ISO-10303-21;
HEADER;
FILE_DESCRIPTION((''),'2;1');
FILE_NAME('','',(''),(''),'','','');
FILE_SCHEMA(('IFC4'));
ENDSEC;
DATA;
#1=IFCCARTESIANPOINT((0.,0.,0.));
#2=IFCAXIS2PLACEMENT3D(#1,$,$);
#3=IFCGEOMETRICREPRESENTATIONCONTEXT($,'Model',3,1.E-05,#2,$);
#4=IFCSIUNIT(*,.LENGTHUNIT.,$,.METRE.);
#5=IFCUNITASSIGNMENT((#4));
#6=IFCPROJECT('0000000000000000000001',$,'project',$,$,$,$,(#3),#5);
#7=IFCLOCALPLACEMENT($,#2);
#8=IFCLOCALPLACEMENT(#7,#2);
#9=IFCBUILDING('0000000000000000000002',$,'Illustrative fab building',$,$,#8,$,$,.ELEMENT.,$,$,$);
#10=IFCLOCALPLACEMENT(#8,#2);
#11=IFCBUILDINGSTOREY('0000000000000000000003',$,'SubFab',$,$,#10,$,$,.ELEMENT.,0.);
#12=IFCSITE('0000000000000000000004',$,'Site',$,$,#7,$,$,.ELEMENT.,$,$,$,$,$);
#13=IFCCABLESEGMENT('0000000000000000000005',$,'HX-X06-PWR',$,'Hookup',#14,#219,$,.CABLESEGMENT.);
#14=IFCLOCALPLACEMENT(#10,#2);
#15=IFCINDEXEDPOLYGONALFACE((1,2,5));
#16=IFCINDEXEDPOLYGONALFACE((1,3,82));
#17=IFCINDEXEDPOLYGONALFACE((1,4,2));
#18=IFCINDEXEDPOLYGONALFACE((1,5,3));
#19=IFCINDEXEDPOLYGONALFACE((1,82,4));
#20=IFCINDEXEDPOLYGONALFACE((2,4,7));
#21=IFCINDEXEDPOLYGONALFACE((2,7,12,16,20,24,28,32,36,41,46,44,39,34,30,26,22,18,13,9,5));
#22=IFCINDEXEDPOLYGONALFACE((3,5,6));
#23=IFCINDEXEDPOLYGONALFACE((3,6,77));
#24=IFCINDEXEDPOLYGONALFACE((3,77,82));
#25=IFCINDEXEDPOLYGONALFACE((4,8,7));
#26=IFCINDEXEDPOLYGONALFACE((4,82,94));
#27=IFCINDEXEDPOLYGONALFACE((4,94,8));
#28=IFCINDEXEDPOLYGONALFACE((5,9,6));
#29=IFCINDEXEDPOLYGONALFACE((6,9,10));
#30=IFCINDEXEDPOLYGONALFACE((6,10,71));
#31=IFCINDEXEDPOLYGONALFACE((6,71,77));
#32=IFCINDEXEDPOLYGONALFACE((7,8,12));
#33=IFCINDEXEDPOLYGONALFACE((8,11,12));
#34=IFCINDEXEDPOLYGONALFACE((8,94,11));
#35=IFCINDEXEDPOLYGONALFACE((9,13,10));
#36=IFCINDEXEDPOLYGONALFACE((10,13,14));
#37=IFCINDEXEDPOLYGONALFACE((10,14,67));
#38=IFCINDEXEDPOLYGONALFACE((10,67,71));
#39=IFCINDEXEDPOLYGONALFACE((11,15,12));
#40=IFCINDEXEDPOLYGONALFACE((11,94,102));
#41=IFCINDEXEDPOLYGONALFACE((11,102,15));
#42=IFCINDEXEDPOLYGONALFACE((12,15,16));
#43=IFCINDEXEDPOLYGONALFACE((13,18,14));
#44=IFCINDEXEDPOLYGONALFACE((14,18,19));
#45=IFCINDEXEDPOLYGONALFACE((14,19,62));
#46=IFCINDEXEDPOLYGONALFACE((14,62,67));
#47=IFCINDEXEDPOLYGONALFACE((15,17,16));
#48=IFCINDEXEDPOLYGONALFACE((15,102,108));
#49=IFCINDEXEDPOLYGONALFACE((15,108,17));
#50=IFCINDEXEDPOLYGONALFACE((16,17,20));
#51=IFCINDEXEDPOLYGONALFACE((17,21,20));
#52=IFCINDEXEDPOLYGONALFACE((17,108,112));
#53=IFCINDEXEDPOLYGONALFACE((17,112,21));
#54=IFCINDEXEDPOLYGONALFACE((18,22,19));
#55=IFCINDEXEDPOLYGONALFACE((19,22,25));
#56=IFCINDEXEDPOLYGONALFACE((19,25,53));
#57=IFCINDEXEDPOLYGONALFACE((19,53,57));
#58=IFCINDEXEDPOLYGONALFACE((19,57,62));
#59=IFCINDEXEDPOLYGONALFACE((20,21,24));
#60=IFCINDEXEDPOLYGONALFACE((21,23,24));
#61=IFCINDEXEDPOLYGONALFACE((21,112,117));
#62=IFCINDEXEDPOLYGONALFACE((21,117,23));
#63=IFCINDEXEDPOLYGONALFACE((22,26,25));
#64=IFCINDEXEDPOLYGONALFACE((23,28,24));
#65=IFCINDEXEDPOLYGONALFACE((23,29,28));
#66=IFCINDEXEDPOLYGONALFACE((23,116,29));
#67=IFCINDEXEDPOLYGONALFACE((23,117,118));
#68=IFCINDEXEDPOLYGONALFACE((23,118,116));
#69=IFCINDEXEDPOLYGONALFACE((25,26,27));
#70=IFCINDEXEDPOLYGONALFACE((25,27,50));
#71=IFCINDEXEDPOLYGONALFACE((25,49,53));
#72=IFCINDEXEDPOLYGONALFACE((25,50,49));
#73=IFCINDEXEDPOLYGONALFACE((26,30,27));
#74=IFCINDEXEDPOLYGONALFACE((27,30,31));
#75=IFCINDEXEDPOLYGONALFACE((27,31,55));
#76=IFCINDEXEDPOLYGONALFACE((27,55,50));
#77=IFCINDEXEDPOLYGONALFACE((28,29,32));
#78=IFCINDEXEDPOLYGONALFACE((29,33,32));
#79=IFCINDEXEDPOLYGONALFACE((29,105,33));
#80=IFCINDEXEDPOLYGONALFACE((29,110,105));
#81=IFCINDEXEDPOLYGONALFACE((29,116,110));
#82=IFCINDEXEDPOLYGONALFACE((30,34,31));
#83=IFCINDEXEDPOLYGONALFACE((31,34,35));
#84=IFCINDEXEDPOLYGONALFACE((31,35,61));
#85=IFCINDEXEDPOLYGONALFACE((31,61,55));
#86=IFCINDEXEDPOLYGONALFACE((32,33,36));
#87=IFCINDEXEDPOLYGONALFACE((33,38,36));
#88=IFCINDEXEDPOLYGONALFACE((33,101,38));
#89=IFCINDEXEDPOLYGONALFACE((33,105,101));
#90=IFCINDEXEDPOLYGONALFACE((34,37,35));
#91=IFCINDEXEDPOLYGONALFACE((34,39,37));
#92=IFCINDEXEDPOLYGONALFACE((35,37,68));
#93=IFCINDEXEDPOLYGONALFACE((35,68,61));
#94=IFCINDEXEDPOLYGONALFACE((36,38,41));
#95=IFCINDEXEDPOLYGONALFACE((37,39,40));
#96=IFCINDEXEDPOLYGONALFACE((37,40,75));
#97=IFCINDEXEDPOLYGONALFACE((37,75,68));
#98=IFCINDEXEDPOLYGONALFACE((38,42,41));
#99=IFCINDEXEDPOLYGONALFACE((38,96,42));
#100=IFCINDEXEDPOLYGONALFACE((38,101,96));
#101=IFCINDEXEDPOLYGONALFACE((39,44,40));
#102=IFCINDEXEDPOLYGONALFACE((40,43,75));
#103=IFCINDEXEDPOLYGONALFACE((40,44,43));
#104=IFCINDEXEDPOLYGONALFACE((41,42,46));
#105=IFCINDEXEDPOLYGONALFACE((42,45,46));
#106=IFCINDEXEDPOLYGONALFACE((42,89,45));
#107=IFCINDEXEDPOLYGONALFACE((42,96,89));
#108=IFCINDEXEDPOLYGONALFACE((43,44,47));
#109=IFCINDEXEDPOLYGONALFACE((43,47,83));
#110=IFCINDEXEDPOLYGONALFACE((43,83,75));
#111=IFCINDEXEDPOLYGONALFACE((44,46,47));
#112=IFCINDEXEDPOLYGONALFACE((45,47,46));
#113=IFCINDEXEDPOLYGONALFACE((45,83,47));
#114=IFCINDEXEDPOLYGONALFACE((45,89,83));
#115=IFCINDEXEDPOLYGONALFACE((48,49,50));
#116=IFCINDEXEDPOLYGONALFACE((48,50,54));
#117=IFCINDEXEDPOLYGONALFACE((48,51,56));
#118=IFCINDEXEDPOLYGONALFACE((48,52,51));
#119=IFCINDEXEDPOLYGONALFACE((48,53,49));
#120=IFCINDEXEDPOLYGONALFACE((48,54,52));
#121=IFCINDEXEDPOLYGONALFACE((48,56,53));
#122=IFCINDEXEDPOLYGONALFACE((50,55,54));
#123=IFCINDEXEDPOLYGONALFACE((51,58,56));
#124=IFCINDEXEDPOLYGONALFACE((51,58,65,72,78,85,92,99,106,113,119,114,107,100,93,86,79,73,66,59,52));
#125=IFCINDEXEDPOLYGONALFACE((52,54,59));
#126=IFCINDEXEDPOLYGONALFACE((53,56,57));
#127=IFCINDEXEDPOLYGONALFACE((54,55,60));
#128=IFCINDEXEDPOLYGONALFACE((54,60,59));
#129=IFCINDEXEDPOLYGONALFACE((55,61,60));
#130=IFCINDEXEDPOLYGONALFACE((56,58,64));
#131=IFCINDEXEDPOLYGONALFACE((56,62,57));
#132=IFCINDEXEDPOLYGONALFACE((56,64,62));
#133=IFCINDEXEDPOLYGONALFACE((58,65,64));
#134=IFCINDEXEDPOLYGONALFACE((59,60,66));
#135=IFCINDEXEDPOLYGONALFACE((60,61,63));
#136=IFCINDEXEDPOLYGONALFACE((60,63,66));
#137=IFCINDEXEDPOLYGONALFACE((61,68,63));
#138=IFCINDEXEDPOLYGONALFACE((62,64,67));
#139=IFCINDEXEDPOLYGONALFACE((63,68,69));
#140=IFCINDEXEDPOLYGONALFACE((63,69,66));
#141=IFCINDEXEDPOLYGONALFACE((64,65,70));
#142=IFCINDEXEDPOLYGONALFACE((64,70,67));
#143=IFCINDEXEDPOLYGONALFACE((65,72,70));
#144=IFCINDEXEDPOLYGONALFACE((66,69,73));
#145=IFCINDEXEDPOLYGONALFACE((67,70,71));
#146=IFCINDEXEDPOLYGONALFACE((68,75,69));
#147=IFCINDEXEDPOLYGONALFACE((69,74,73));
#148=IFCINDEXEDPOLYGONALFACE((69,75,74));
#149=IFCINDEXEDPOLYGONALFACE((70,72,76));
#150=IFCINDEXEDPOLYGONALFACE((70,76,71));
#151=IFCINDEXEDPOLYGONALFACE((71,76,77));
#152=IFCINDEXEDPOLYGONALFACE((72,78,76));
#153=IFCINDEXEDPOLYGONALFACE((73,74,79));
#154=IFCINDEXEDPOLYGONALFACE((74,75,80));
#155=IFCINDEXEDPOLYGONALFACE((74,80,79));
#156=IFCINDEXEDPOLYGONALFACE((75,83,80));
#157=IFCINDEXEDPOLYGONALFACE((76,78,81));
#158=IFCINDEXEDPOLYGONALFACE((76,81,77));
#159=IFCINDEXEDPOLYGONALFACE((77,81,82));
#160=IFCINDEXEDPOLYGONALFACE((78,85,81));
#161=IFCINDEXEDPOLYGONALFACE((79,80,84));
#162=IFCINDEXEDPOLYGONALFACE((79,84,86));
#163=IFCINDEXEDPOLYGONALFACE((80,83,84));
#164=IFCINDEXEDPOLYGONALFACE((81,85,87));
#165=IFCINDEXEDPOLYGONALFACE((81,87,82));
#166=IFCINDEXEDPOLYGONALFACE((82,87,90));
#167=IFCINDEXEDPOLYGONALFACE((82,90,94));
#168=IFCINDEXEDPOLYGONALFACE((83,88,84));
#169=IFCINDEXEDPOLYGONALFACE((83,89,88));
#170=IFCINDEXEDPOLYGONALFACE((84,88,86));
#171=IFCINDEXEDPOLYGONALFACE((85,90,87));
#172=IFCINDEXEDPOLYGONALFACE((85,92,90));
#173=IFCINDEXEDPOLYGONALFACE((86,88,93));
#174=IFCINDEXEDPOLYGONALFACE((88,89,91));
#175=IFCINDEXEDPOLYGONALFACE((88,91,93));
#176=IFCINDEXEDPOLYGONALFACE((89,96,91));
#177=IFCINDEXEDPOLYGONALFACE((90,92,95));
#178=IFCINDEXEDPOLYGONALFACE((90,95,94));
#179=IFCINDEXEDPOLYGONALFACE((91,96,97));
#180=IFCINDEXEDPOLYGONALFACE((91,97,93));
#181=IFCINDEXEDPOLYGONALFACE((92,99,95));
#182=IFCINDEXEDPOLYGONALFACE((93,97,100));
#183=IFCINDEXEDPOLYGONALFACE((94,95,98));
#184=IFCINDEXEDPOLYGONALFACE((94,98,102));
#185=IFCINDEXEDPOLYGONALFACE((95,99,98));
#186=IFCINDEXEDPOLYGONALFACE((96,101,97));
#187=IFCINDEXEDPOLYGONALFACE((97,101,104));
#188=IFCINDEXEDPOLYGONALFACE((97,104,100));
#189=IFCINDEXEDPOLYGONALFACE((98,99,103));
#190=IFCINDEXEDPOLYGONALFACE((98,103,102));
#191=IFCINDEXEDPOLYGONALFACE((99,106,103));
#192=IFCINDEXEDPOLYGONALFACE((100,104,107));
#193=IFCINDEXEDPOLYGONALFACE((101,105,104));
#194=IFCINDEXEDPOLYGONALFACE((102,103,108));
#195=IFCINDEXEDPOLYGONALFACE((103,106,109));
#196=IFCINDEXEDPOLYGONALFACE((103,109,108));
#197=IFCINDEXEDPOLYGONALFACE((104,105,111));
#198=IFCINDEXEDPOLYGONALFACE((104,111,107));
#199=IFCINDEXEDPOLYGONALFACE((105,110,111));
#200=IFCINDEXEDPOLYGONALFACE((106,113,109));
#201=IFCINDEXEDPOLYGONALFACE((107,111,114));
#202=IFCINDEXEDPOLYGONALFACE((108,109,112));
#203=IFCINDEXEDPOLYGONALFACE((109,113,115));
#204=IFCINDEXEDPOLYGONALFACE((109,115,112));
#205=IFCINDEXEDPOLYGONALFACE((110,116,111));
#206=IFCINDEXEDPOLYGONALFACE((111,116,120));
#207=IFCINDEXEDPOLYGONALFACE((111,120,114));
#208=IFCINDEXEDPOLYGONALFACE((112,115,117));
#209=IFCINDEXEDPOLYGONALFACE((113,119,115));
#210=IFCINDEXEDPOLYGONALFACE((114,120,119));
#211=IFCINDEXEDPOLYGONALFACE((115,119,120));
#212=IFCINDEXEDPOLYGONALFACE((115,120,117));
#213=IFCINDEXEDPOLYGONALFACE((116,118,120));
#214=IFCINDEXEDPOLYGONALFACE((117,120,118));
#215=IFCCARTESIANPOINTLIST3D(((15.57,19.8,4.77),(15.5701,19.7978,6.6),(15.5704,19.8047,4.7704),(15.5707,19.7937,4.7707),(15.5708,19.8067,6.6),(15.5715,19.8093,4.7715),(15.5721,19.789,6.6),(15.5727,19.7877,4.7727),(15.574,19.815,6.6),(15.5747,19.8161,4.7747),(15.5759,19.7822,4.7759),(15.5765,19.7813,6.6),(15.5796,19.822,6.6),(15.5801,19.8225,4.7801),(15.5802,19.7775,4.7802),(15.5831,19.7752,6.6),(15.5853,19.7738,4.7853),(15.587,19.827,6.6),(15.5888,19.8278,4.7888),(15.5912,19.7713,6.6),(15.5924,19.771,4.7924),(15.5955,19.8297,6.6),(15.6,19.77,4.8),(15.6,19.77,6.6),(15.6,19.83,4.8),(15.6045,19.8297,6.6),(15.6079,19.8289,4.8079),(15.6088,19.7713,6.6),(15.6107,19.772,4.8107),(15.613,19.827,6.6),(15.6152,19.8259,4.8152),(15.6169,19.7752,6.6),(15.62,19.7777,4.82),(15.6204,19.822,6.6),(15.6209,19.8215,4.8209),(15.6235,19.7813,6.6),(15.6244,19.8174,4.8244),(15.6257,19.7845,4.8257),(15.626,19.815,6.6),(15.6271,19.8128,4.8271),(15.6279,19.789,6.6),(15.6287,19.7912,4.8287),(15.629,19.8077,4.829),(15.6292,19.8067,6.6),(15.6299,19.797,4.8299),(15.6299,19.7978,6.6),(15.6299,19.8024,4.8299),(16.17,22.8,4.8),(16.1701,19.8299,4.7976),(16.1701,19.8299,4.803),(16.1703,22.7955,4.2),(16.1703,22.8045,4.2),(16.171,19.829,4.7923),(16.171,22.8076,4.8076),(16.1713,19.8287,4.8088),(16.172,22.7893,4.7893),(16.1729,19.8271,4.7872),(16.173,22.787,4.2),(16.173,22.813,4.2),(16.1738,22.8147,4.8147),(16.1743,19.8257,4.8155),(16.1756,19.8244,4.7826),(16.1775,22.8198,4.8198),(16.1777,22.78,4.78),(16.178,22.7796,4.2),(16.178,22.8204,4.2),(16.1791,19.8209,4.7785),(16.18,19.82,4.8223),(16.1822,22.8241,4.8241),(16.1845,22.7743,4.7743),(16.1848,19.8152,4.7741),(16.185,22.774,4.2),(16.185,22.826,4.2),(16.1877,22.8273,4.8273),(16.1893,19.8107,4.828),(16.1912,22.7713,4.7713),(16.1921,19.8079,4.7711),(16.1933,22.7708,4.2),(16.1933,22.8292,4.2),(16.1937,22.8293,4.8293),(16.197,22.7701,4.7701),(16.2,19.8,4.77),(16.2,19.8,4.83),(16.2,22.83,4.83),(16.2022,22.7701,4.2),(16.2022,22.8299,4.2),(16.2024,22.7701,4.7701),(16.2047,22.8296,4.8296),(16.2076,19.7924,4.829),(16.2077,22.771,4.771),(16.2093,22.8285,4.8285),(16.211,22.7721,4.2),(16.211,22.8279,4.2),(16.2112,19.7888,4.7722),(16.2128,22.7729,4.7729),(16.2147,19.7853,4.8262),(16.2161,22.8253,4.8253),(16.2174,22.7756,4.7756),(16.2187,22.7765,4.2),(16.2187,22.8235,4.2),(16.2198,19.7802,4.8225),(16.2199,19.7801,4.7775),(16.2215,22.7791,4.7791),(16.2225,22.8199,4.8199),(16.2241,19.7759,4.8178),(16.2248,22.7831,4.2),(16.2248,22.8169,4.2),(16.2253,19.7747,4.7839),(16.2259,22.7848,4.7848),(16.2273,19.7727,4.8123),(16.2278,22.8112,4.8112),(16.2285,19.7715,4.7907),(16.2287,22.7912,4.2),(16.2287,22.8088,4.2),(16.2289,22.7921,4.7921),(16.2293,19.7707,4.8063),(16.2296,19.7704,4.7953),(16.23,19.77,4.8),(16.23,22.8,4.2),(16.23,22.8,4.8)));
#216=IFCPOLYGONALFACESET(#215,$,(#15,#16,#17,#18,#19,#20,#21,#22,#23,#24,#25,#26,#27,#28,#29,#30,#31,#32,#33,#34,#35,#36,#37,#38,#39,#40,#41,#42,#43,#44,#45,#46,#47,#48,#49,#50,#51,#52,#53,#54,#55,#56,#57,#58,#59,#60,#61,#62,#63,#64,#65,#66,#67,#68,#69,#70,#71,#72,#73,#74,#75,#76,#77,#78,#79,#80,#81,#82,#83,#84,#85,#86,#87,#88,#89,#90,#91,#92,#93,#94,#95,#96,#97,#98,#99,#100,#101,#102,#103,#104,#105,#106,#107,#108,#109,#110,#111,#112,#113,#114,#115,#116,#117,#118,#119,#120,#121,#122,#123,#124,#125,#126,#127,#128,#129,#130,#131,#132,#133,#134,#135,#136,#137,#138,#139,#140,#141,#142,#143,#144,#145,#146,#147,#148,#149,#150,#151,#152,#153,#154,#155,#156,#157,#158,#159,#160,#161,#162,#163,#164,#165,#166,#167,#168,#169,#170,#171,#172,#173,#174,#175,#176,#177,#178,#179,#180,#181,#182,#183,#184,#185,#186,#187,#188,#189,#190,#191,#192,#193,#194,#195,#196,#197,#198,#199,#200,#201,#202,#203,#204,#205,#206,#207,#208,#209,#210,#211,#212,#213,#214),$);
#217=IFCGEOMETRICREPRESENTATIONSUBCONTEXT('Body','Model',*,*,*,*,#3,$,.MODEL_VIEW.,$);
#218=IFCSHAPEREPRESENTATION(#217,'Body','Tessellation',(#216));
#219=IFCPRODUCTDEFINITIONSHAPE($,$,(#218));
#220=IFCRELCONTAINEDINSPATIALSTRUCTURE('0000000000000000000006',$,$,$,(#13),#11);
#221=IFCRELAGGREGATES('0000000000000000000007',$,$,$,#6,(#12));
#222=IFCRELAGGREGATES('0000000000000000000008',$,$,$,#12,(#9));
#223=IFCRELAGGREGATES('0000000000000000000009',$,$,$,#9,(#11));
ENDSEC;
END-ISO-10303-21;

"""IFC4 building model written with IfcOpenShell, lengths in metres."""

from ifc_helpers import new_model, entity, si_unit, origin, place, context, subcontext, project, spatial, element, save


model = new_model("IFC4")

# Units and contexts
model_context = context("Model", 3, precision=1e-05, world=origin())
body_context = subcontext(model_context, "Body", "Model", "MODEL_VIEW")
ifc_project = project(units=[si_unit("LENGTHUNIT", "METRE")], contexts=[model_context])

# Site, building, storey
site_placement = place(None, origin())
site = spatial("IfcSite", under=ifc_project, at=site_placement, Name="Site", CompositionType="ELEMENT")
building_placement = place(site_placement, origin())
building = spatial("IfcBuilding", under=site, at=building_placement, Name="Illustrative fab building", CompositionType="ELEMENT")
storey_placement = place(building_placement, origin())
storey = spatial("IfcBuildingStorey", under=building, at=storey_placement, Name="SubFab", CompositionType="ELEMENT", Elevation=0.0)

# Cable segment
cable_segment_1_placement = place(storey_placement, origin())
element("IfcCableSegment", 1, at=cable_segment_1_placement, inside=storey, Name="HX-X06-PWR", ObjectType="Hookup", PredefinedType="CABLESEGMENT", context=body_context, shape_type="AdvancedSweptSolid", body=[
    entity("IfcSweptDiskSolid", entity("IfcPolyline", [entity("IfcCartesianPoint", [16.2, 22.8, 4.2]), entity("IfcCartesianPoint", [16.2, 22.8, 4.8]), entity("IfcCartesianPoint", [16.2, 19.8, 4.8]), entity("IfcCartesianPoint", [15.6, 19.8, 4.8]), entity("IfcCartesianPoint", [15.6, 19.8, 6.6])]), 0.03),
])

save(model, "model.ifc")
